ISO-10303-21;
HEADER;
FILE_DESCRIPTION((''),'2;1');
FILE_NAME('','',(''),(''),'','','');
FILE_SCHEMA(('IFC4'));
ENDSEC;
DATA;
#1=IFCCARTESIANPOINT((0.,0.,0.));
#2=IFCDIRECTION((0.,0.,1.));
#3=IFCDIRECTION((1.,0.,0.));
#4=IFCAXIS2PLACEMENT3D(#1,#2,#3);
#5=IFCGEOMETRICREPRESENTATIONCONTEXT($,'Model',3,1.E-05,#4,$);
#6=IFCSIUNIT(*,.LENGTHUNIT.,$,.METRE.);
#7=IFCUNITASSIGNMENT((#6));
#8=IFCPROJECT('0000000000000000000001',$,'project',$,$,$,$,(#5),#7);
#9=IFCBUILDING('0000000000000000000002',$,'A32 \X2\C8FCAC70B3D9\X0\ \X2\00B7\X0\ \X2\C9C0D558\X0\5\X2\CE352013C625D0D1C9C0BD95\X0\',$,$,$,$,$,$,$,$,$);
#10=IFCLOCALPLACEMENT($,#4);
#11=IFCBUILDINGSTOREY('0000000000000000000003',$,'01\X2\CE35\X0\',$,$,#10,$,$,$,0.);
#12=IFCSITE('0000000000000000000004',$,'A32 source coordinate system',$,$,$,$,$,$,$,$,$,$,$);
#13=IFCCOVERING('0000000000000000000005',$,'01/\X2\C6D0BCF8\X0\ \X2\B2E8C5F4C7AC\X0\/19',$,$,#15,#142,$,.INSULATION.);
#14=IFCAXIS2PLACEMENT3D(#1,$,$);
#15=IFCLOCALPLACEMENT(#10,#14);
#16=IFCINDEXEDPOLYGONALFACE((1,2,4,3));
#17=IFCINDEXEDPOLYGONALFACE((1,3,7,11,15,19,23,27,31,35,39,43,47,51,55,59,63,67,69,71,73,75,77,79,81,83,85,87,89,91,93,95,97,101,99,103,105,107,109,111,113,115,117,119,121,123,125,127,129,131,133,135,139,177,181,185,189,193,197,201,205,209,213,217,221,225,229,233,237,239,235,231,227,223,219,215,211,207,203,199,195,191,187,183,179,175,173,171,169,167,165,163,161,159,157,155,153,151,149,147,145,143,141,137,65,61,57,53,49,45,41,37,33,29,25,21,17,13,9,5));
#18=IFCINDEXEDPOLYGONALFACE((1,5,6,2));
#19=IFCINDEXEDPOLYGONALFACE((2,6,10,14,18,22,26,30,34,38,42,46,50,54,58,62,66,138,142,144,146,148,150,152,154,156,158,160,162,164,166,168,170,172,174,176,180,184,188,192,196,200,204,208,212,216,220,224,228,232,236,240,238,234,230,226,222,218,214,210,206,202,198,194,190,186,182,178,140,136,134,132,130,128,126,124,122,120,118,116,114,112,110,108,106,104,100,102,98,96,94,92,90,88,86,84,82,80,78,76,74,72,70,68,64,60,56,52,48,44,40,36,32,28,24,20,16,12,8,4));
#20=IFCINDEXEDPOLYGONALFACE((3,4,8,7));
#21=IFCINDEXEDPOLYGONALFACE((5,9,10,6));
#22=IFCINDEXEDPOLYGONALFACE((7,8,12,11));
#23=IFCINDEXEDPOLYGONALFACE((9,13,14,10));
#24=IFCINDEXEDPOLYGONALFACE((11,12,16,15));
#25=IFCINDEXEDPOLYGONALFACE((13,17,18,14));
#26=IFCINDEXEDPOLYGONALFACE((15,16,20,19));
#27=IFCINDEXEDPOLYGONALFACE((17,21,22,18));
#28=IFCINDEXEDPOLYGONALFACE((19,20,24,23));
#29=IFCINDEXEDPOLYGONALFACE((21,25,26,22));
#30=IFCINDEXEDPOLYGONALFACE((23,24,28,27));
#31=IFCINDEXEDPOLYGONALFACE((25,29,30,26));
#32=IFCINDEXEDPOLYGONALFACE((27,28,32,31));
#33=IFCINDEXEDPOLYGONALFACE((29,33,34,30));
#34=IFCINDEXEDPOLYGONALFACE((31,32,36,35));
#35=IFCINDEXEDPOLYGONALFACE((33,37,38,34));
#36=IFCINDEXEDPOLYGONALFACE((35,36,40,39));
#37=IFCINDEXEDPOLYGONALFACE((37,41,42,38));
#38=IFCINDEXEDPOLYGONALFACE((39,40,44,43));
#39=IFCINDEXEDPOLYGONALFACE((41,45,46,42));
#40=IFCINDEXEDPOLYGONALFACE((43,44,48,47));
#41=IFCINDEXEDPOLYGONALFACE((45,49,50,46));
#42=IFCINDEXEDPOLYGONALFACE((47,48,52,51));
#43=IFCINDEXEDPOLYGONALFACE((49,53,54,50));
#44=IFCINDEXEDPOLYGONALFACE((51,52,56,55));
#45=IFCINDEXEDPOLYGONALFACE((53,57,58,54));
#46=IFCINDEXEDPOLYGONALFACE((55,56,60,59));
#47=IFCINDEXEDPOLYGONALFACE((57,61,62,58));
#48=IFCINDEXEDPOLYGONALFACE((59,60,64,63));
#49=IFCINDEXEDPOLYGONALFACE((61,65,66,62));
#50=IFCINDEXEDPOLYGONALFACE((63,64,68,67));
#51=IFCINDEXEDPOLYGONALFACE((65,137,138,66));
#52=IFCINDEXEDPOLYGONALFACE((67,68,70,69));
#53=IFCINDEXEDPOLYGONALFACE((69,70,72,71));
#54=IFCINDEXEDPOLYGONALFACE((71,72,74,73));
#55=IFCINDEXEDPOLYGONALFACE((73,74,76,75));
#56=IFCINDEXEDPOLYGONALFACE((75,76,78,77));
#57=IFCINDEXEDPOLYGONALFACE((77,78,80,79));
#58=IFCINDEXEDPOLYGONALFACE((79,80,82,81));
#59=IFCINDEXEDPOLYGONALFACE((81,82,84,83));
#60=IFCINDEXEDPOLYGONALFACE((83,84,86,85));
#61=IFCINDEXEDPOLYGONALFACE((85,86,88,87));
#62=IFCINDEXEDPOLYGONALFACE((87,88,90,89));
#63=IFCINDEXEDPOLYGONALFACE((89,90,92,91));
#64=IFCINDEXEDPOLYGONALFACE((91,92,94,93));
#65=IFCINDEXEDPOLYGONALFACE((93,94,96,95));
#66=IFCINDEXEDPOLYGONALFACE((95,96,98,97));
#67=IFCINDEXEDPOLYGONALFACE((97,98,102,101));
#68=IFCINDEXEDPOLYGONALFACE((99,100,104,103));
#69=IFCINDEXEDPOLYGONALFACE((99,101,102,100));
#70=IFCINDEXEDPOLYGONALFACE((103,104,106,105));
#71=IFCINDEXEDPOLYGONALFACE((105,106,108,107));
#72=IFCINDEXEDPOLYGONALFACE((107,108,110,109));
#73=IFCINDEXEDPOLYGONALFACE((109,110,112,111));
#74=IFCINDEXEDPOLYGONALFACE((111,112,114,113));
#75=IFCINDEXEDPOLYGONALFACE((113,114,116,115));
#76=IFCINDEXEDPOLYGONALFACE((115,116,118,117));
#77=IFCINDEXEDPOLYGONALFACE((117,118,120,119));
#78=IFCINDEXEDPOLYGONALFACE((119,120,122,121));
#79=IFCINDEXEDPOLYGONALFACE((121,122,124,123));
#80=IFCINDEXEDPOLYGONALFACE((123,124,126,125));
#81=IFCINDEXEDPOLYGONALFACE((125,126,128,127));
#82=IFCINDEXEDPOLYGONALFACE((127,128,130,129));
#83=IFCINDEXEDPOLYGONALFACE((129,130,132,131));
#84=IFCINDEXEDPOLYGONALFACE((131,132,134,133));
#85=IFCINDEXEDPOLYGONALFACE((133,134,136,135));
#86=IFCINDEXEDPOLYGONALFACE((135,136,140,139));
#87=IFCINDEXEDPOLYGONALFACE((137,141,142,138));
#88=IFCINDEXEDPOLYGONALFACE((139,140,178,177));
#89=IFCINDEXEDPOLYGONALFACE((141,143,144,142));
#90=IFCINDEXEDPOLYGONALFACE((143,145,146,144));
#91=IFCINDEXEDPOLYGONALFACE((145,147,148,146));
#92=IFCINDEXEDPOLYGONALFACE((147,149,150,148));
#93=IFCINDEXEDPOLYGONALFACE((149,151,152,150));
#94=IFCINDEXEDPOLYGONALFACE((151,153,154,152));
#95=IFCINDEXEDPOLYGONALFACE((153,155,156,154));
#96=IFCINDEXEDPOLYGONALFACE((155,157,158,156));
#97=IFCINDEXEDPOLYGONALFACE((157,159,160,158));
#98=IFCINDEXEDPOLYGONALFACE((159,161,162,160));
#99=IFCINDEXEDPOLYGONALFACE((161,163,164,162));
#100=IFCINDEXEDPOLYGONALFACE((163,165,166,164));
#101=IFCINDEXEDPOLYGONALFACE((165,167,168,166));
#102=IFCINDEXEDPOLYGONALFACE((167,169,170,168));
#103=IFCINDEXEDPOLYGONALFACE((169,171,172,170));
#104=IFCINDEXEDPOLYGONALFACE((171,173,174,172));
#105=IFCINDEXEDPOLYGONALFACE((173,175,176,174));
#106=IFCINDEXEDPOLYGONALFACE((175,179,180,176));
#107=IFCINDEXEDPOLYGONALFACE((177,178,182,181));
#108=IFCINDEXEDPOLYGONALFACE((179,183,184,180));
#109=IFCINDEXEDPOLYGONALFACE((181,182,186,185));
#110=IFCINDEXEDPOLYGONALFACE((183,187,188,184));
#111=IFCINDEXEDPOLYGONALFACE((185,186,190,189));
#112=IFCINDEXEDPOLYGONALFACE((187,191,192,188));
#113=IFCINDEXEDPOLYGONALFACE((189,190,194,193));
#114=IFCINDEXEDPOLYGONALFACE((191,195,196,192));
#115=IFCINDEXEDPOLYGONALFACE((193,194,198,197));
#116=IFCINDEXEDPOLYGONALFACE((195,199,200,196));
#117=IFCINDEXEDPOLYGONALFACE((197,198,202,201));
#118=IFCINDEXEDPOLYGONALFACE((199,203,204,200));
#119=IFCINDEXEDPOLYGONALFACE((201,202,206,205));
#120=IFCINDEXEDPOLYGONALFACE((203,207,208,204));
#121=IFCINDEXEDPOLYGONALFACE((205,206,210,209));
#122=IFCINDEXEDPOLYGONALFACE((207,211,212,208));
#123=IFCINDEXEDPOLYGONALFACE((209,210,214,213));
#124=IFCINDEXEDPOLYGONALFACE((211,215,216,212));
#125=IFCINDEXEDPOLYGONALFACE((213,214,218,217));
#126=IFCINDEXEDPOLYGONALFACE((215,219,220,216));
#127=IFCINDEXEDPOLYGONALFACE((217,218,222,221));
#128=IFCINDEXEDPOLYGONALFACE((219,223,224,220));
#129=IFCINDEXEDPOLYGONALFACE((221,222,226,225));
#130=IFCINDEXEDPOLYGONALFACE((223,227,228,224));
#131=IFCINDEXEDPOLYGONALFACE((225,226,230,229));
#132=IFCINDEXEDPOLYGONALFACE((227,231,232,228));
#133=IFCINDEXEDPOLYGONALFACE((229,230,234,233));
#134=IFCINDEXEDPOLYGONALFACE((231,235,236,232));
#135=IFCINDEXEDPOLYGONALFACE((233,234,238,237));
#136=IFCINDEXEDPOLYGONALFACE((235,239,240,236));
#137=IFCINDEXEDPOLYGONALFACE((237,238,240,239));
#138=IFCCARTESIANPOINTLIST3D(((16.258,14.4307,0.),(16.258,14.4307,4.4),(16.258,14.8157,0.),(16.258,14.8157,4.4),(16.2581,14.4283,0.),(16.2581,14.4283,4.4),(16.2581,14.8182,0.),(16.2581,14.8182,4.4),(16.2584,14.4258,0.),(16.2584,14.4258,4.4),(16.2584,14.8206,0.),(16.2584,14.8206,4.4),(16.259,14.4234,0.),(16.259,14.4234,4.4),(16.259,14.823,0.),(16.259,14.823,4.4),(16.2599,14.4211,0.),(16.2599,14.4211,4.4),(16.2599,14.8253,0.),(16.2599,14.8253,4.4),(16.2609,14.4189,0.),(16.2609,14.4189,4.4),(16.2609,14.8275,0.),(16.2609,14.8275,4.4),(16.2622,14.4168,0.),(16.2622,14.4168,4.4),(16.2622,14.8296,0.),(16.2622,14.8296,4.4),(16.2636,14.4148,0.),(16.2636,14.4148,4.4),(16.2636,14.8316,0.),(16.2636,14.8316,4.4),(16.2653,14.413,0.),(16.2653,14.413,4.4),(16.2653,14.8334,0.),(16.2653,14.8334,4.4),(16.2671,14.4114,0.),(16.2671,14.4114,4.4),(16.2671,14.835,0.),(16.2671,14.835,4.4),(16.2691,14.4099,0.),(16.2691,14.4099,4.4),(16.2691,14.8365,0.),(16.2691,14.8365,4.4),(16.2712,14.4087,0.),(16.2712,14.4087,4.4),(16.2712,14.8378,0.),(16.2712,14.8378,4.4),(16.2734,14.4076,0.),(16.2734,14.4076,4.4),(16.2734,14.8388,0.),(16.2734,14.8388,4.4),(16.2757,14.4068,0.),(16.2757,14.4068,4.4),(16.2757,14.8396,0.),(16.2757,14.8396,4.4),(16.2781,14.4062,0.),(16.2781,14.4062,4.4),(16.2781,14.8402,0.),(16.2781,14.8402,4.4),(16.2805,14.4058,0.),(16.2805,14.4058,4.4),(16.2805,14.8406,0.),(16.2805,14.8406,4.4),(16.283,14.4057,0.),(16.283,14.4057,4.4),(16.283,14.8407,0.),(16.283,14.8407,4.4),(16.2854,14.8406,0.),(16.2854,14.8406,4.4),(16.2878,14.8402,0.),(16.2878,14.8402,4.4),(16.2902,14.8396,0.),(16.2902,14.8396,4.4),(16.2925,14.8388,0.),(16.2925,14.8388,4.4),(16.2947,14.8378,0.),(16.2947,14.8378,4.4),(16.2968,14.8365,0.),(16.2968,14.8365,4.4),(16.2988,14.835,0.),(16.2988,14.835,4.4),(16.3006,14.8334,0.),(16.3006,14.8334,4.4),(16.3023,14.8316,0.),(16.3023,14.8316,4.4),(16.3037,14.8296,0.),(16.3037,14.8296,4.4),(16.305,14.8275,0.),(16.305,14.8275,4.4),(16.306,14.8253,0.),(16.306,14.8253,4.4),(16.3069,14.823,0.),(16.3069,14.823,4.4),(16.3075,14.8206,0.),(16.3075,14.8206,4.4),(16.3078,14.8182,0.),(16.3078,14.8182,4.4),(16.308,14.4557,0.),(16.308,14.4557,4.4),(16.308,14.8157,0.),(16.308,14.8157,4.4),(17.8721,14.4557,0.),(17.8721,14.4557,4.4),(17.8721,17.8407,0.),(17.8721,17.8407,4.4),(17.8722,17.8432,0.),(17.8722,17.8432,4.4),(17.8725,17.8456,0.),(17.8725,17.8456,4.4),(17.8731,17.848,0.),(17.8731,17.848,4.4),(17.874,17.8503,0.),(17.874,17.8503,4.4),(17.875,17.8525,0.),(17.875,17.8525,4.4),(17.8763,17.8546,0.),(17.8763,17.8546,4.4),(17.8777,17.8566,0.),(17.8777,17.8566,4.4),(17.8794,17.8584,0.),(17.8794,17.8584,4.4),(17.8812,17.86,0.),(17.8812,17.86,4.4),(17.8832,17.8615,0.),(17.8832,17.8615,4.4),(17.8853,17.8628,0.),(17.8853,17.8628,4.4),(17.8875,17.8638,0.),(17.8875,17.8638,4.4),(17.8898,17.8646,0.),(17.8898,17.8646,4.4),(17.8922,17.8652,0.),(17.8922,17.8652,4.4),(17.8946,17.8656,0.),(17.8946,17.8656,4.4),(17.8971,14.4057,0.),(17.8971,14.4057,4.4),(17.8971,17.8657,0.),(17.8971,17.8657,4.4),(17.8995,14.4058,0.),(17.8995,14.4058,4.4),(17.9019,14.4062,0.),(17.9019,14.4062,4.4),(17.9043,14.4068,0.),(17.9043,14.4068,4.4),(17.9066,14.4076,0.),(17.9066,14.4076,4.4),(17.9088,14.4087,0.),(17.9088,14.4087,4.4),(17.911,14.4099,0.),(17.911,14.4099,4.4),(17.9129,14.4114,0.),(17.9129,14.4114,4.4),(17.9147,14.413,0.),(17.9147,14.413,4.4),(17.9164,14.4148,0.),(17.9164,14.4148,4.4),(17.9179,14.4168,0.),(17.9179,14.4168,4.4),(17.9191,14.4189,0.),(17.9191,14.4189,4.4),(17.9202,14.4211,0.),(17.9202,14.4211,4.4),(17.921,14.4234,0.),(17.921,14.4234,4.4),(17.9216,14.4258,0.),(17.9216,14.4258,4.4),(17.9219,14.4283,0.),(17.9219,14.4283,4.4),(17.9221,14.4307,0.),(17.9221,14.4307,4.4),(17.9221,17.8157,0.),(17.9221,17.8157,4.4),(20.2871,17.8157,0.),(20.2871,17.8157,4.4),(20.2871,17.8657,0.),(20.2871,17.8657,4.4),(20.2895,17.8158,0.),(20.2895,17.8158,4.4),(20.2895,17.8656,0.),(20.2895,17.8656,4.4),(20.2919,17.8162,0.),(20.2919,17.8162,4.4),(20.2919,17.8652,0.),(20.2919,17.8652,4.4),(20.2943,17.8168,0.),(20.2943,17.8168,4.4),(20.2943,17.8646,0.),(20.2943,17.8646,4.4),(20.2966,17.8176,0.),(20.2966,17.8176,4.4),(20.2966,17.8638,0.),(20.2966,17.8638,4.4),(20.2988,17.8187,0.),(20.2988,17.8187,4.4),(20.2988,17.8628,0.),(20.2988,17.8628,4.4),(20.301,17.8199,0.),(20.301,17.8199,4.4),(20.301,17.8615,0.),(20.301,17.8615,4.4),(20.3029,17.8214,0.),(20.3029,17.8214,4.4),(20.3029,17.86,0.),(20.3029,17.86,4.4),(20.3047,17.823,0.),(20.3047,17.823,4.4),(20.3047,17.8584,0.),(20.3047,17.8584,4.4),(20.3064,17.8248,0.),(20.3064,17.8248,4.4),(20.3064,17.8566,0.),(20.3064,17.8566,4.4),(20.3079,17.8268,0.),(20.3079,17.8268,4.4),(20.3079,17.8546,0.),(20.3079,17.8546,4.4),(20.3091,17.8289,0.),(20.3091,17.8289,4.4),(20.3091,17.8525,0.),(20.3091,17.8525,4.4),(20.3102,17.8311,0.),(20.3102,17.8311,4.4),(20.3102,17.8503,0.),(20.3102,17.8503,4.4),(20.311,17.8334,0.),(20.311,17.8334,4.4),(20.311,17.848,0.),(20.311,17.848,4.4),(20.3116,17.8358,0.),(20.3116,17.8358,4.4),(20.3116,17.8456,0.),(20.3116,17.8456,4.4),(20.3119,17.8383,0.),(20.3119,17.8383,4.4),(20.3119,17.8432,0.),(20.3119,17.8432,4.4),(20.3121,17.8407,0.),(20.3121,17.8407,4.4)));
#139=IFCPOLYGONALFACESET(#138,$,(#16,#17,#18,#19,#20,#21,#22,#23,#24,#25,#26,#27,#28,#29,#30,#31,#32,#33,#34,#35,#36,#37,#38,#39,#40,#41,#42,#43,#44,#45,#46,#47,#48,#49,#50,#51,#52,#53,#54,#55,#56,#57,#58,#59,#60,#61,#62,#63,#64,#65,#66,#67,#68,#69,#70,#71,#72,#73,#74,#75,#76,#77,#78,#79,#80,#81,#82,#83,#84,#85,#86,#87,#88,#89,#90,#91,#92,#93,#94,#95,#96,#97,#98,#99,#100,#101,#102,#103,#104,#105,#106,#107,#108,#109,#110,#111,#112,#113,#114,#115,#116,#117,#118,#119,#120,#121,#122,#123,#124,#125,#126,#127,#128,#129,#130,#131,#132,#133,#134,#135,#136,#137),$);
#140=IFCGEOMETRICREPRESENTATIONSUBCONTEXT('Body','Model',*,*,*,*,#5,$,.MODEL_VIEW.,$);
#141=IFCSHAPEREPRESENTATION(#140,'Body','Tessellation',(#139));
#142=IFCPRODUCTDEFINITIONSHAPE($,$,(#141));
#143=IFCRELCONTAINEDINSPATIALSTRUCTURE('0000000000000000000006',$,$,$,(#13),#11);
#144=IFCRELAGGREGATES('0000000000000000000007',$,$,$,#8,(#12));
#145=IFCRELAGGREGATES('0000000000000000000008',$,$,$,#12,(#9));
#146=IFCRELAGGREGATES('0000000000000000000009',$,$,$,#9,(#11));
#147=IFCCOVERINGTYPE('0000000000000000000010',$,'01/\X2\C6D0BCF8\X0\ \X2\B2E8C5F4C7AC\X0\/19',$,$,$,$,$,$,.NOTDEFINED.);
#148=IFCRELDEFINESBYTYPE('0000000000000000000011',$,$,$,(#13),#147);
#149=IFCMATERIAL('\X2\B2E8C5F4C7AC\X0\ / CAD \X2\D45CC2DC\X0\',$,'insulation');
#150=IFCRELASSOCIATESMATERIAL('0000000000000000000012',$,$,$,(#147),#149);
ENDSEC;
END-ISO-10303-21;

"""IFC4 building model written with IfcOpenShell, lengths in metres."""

from ifc_helpers import new_model, si_unit, origin, origin_with_axes, place, context, subcontext, project, spatial, polyline, outline, extrude, source, transform, mapped, material, type_object, type_shapes, element, save


model = new_model("IFC4")

# Units and contexts
model_context = context("Model", 3, precision=1e-05, world=origin_with_axes())
body_context = subcontext(model_context, "Body", "Model", "MODEL_VIEW")
ifc_project = project(units=[si_unit("LENGTHUNIT", "METRE")], contexts=[model_context])

# Site, building, storey
site = spatial("IfcSite", under=ifc_project, Name="A32 source coordinate system")
building = spatial("IfcBuilding", under=site, Name="A32 주거동 · 지하5층–옥탑지붕")
storey_placement = place(None, origin_with_axes())
storey = spatial("IfcBuildingStorey", under=building, at=storey_placement, Name="01층", Elevation=0.0)

# Covering
ifc_material = material(Name="단열재 / CAD 표시", Category="insulation")
covering_type_1 = type_object("IfcCoveringType", Name="01/원본 단열재/19", PredefinedType="NOTDEFINED", material=ifc_material)
shared_shape_1 = source(origin(), body_context, "Body", "SweptSolid", [
    extrude(outline(polyline([(16.2609, 14.8275), (16.2622, 14.8296), (16.2636, 14.8316), (16.2653, 14.8334), (16.2671, 14.835), (16.2691, 14.8365), (16.2712, 14.8378), (16.2734, 14.8388), (16.2757, 14.8396), (16.2781, 14.8402), (16.2805, 14.8406), (16.283, 14.8407), (16.2854, 14.8406), (16.2878, 14.8402), (16.2902, 14.8396), (16.2925, 14.8388), (16.2947, 14.8378), (16.2968, 14.8365), (16.2988, 14.835), (16.3006, 14.8334), (16.3023, 14.8316), (16.3037, 14.8296), (16.305, 14.8275), (16.306, 14.8253), (16.3069, 14.823), (16.3075, 14.8206), (16.3078, 14.8182), (16.308, 14.8157), (16.308, 14.4557), (17.8721, 14.4557), (17.8721, 17.8407), (17.8722, 17.8432), (17.8725, 17.8456), (17.8731, 17.848), (17.874, 17.8503), (17.875, 17.8525), (17.8763, 17.8546), (17.8777, 17.8566), (17.8794, 17.8584), (17.8812, 17.86), (17.8832, 17.8615), (17.8853, 17.8628), (17.8875, 17.8638), (17.8898, 17.8646), (17.8922, 17.8652), (17.8946, 17.8656), (17.8971, 17.8657), (20.2871, 17.8657), (20.2895, 17.8656), (20.2919, 17.8652), (20.2943, 17.8646), (20.2966, 17.8638), (20.2988, 17.8628), (20.301, 17.8615), (20.3029, 17.86), (20.3047, 17.8584), (20.3064, 17.8566), (20.3079, 17.8546), (20.3091, 17.8525), (20.3102, 17.8503), (20.311, 17.848), (20.3116, 17.8456), (20.3119, 17.8432), (20.3121, 17.8407), (20.3119, 17.8383), (20.3116, 17.8358), (20.311, 17.8334), (20.3102, 17.8311), (20.3091, 17.8289), (20.3079, 17.8268), (20.3064, 17.8248), (20.3047, 17.823), (20.3029, 17.8214), (20.301, 17.8199), (20.2988, 17.8187), (20.2966, 17.8176), (20.2943, 17.8168), (20.2919, 17.8162), (20.2895, 17.8158), (20.2871, 17.8157), (17.9221, 17.8157), (17.9221, 14.4307), (17.9219, 14.4283), (17.9216, 14.4258), (17.921, 14.4234), (17.9202, 14.4211), (17.9191, 14.4189), (17.9179, 14.4168), (17.9164, 14.4148), (17.9147, 14.413), (17.9129, 14.4114), (17.911, 14.4099), (17.9088, 14.4087), (17.9066, 14.4076), (17.9043, 14.4068), (17.9019, 14.4062), (17.8995, 14.4058), (17.8971, 14.4057), (16.283, 14.4057), (16.2805, 14.4058), (16.2781, 14.4062), (16.2757, 14.4068), (16.2734, 14.4076), (16.2712, 14.4087), (16.2691, 14.4099), (16.2671, 14.4114), (16.2653, 14.413), (16.2636, 14.4148), (16.2622, 14.4168), (16.2609, 14.4189), (16.2599, 14.4211), (16.259, 14.4234), (16.2584, 14.4258), (16.2581, 14.4283), (16.258, 14.4307), (16.258, 14.8157), (16.2581, 14.8182), (16.2584, 14.8206), (16.259, 14.823), (16.2599, 14.8253), (16.2609, 14.8275)])), origin(), (0.0, 0.0, 1.0), 4.4),
])
type_shapes(covering_type_1, [shared_shape_1])
covering_1_placement = place(storey_placement, origin_with_axes())
element("IfcCovering", 1, at=covering_1_placement, inside=storey, type_object=covering_type_1, Name="01/원본 단열재/19", PredefinedType="INSULATION", context=body_context, shape_type="MappedRepresentation", body=[
    mapped(shared_shape_1, transform((0.0, 0.0, 0.0), scale=1.0)),
])

save(model, "model.ifc")
